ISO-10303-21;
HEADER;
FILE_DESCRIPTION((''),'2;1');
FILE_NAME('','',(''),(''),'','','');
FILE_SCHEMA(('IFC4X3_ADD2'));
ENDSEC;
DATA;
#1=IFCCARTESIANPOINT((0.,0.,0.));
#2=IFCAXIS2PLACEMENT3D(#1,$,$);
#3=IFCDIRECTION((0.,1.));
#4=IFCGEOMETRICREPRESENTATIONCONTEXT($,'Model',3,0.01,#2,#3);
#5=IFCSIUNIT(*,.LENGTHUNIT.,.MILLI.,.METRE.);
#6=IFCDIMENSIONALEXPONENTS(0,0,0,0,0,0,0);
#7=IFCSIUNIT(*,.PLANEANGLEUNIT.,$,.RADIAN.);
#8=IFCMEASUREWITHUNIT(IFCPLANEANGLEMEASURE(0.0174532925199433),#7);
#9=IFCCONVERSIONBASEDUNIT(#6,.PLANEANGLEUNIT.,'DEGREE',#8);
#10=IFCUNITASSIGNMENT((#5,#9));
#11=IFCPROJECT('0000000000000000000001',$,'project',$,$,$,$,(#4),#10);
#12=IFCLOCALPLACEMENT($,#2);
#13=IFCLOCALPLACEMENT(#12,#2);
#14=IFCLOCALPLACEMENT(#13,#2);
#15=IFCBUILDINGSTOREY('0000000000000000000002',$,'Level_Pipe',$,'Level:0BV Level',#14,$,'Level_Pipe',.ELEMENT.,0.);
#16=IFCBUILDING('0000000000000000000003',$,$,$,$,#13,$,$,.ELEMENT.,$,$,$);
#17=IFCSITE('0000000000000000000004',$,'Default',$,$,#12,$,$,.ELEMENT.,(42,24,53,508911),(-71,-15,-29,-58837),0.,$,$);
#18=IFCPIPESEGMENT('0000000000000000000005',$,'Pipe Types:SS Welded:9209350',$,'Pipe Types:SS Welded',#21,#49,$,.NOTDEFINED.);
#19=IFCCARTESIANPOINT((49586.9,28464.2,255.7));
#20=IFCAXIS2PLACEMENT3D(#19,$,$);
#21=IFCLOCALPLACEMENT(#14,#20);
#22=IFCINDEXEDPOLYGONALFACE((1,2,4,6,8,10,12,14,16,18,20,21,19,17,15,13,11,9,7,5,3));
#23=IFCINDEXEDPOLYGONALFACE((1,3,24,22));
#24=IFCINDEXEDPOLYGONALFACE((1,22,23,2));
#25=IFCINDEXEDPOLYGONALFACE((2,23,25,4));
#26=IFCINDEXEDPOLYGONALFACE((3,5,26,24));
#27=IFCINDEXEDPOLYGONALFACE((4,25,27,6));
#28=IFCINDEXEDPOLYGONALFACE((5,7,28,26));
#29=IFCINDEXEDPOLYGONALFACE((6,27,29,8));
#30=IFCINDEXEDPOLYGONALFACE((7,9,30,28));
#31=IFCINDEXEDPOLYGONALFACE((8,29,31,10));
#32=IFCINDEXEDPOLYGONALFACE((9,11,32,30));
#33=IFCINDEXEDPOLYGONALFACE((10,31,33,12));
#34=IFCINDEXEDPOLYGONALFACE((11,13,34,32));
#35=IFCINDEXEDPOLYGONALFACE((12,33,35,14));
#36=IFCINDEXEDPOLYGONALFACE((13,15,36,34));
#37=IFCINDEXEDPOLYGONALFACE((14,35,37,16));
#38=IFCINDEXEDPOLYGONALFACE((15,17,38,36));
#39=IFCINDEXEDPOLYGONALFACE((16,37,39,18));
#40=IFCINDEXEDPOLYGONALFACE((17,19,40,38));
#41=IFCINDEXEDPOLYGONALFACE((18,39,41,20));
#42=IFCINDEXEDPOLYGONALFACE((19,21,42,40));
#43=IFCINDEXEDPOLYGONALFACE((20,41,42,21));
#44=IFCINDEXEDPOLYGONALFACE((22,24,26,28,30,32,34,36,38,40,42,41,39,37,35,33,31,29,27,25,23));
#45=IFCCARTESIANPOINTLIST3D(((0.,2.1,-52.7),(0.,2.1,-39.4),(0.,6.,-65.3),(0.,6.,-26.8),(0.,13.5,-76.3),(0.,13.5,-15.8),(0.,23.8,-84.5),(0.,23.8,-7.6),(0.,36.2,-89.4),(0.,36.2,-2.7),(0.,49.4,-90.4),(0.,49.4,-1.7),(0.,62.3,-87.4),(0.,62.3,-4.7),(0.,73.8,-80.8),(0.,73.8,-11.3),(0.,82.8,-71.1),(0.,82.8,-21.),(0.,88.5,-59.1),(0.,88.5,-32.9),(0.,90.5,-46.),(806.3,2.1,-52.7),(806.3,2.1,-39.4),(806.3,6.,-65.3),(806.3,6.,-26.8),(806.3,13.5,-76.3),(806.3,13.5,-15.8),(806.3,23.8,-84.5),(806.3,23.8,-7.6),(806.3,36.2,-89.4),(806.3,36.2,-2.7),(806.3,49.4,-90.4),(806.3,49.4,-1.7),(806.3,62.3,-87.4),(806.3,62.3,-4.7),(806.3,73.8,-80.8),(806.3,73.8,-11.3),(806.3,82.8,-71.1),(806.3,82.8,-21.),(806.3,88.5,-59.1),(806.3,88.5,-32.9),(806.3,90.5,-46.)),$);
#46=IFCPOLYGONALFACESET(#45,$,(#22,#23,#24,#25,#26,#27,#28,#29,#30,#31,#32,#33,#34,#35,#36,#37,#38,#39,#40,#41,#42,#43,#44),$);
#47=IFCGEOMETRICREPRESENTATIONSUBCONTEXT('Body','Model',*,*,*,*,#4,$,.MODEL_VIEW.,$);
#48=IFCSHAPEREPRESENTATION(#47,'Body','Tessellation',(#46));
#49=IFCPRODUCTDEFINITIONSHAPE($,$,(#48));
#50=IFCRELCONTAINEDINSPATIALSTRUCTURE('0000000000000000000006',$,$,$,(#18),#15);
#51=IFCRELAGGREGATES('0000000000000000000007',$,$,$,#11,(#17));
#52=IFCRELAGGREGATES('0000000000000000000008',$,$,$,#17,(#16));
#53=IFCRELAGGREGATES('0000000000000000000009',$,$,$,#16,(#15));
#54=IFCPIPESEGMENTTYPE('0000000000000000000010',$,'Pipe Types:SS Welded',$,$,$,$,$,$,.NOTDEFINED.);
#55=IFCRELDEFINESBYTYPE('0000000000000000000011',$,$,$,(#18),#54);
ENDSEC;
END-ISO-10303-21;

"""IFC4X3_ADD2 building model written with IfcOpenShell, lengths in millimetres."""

from ifc_helpers import new_model, entity, si_unit, converted_unit, direction, frame, frame_2d, origin, place, context, subcontext, project, spatial, circle, extrude, type_object, element, save


model = new_model("IFC4X3_ADD2")

# Units and contexts
model_context = context("Model", 3, precision=0.01, world=origin(), true_north=direction((0.0, 1.0)))
body_context = subcontext(model_context, "Body", "Model", "MODEL_VIEW")
ifc_project = project(units=[si_unit("LENGTHUNIT", "METRE", prefix="MILLI"), converted_unit("PLANEANGLEUNIT", "DEGREE", entity("IfcPlaneAngleMeasure", 0.0174532925199433), si_unit("PLANEANGLEUNIT", "RADIAN"), dimensions=[0, 0, 0, 0, 0, 0, 0])], contexts=[model_context])

# Site, building, storey
site_placement = place(None, origin())
site = spatial("IfcSite", under=ifc_project, at=site_placement, Name="Default", CompositionType="ELEMENT", RefLatitude=(42, 24, 53, 508911), RefLongitude=(-71, -15, -29, -58837), RefElevation=0.0)
building_placement = place(site_placement, origin())
building = spatial("IfcBuilding", under=site, at=building_placement, CompositionType="ELEMENT")
storey_placement = place(building_placement, origin())
storey = spatial("IfcBuildingStorey", under=building, at=storey_placement, Name="Level_Pipe", ObjectType="Level:0BV Level", LongName="Level_Pipe", CompositionType="ELEMENT", Elevation=0.0)

# Pipe segment
pipe_segment_type = type_object("IfcPipeSegmentType", Name="Pipe Types:SS Welded", PredefinedType="NOTDEFINED")
pipe_segment_placement = place(storey_placement, frame((49586.9, 28464.2, 255.7)))
element("IfcPipeSegment", 1, at=pipe_segment_placement, inside=storey, type_object=pipe_segment_type, Name="Pipe Types:SS Welded:9209350", ObjectType="Pipe Types:SS Welded", PredefinedType="NOTDEFINED", context=body_context, shape_type="SweptSolid", body=[
    extrude(circle(Radius=44.5, at=frame_2d((0.0, 0.0), x_axis=(1.0, 0.0))), frame((0.0, 46.0, -46.0), z_axis=(1.0, 0.0, 0.0), x_axis=(0.0, 1.0, 0.0)), (0.0, 0.0, 1.0), 806.3),
])

save(model, "model.ifc")
